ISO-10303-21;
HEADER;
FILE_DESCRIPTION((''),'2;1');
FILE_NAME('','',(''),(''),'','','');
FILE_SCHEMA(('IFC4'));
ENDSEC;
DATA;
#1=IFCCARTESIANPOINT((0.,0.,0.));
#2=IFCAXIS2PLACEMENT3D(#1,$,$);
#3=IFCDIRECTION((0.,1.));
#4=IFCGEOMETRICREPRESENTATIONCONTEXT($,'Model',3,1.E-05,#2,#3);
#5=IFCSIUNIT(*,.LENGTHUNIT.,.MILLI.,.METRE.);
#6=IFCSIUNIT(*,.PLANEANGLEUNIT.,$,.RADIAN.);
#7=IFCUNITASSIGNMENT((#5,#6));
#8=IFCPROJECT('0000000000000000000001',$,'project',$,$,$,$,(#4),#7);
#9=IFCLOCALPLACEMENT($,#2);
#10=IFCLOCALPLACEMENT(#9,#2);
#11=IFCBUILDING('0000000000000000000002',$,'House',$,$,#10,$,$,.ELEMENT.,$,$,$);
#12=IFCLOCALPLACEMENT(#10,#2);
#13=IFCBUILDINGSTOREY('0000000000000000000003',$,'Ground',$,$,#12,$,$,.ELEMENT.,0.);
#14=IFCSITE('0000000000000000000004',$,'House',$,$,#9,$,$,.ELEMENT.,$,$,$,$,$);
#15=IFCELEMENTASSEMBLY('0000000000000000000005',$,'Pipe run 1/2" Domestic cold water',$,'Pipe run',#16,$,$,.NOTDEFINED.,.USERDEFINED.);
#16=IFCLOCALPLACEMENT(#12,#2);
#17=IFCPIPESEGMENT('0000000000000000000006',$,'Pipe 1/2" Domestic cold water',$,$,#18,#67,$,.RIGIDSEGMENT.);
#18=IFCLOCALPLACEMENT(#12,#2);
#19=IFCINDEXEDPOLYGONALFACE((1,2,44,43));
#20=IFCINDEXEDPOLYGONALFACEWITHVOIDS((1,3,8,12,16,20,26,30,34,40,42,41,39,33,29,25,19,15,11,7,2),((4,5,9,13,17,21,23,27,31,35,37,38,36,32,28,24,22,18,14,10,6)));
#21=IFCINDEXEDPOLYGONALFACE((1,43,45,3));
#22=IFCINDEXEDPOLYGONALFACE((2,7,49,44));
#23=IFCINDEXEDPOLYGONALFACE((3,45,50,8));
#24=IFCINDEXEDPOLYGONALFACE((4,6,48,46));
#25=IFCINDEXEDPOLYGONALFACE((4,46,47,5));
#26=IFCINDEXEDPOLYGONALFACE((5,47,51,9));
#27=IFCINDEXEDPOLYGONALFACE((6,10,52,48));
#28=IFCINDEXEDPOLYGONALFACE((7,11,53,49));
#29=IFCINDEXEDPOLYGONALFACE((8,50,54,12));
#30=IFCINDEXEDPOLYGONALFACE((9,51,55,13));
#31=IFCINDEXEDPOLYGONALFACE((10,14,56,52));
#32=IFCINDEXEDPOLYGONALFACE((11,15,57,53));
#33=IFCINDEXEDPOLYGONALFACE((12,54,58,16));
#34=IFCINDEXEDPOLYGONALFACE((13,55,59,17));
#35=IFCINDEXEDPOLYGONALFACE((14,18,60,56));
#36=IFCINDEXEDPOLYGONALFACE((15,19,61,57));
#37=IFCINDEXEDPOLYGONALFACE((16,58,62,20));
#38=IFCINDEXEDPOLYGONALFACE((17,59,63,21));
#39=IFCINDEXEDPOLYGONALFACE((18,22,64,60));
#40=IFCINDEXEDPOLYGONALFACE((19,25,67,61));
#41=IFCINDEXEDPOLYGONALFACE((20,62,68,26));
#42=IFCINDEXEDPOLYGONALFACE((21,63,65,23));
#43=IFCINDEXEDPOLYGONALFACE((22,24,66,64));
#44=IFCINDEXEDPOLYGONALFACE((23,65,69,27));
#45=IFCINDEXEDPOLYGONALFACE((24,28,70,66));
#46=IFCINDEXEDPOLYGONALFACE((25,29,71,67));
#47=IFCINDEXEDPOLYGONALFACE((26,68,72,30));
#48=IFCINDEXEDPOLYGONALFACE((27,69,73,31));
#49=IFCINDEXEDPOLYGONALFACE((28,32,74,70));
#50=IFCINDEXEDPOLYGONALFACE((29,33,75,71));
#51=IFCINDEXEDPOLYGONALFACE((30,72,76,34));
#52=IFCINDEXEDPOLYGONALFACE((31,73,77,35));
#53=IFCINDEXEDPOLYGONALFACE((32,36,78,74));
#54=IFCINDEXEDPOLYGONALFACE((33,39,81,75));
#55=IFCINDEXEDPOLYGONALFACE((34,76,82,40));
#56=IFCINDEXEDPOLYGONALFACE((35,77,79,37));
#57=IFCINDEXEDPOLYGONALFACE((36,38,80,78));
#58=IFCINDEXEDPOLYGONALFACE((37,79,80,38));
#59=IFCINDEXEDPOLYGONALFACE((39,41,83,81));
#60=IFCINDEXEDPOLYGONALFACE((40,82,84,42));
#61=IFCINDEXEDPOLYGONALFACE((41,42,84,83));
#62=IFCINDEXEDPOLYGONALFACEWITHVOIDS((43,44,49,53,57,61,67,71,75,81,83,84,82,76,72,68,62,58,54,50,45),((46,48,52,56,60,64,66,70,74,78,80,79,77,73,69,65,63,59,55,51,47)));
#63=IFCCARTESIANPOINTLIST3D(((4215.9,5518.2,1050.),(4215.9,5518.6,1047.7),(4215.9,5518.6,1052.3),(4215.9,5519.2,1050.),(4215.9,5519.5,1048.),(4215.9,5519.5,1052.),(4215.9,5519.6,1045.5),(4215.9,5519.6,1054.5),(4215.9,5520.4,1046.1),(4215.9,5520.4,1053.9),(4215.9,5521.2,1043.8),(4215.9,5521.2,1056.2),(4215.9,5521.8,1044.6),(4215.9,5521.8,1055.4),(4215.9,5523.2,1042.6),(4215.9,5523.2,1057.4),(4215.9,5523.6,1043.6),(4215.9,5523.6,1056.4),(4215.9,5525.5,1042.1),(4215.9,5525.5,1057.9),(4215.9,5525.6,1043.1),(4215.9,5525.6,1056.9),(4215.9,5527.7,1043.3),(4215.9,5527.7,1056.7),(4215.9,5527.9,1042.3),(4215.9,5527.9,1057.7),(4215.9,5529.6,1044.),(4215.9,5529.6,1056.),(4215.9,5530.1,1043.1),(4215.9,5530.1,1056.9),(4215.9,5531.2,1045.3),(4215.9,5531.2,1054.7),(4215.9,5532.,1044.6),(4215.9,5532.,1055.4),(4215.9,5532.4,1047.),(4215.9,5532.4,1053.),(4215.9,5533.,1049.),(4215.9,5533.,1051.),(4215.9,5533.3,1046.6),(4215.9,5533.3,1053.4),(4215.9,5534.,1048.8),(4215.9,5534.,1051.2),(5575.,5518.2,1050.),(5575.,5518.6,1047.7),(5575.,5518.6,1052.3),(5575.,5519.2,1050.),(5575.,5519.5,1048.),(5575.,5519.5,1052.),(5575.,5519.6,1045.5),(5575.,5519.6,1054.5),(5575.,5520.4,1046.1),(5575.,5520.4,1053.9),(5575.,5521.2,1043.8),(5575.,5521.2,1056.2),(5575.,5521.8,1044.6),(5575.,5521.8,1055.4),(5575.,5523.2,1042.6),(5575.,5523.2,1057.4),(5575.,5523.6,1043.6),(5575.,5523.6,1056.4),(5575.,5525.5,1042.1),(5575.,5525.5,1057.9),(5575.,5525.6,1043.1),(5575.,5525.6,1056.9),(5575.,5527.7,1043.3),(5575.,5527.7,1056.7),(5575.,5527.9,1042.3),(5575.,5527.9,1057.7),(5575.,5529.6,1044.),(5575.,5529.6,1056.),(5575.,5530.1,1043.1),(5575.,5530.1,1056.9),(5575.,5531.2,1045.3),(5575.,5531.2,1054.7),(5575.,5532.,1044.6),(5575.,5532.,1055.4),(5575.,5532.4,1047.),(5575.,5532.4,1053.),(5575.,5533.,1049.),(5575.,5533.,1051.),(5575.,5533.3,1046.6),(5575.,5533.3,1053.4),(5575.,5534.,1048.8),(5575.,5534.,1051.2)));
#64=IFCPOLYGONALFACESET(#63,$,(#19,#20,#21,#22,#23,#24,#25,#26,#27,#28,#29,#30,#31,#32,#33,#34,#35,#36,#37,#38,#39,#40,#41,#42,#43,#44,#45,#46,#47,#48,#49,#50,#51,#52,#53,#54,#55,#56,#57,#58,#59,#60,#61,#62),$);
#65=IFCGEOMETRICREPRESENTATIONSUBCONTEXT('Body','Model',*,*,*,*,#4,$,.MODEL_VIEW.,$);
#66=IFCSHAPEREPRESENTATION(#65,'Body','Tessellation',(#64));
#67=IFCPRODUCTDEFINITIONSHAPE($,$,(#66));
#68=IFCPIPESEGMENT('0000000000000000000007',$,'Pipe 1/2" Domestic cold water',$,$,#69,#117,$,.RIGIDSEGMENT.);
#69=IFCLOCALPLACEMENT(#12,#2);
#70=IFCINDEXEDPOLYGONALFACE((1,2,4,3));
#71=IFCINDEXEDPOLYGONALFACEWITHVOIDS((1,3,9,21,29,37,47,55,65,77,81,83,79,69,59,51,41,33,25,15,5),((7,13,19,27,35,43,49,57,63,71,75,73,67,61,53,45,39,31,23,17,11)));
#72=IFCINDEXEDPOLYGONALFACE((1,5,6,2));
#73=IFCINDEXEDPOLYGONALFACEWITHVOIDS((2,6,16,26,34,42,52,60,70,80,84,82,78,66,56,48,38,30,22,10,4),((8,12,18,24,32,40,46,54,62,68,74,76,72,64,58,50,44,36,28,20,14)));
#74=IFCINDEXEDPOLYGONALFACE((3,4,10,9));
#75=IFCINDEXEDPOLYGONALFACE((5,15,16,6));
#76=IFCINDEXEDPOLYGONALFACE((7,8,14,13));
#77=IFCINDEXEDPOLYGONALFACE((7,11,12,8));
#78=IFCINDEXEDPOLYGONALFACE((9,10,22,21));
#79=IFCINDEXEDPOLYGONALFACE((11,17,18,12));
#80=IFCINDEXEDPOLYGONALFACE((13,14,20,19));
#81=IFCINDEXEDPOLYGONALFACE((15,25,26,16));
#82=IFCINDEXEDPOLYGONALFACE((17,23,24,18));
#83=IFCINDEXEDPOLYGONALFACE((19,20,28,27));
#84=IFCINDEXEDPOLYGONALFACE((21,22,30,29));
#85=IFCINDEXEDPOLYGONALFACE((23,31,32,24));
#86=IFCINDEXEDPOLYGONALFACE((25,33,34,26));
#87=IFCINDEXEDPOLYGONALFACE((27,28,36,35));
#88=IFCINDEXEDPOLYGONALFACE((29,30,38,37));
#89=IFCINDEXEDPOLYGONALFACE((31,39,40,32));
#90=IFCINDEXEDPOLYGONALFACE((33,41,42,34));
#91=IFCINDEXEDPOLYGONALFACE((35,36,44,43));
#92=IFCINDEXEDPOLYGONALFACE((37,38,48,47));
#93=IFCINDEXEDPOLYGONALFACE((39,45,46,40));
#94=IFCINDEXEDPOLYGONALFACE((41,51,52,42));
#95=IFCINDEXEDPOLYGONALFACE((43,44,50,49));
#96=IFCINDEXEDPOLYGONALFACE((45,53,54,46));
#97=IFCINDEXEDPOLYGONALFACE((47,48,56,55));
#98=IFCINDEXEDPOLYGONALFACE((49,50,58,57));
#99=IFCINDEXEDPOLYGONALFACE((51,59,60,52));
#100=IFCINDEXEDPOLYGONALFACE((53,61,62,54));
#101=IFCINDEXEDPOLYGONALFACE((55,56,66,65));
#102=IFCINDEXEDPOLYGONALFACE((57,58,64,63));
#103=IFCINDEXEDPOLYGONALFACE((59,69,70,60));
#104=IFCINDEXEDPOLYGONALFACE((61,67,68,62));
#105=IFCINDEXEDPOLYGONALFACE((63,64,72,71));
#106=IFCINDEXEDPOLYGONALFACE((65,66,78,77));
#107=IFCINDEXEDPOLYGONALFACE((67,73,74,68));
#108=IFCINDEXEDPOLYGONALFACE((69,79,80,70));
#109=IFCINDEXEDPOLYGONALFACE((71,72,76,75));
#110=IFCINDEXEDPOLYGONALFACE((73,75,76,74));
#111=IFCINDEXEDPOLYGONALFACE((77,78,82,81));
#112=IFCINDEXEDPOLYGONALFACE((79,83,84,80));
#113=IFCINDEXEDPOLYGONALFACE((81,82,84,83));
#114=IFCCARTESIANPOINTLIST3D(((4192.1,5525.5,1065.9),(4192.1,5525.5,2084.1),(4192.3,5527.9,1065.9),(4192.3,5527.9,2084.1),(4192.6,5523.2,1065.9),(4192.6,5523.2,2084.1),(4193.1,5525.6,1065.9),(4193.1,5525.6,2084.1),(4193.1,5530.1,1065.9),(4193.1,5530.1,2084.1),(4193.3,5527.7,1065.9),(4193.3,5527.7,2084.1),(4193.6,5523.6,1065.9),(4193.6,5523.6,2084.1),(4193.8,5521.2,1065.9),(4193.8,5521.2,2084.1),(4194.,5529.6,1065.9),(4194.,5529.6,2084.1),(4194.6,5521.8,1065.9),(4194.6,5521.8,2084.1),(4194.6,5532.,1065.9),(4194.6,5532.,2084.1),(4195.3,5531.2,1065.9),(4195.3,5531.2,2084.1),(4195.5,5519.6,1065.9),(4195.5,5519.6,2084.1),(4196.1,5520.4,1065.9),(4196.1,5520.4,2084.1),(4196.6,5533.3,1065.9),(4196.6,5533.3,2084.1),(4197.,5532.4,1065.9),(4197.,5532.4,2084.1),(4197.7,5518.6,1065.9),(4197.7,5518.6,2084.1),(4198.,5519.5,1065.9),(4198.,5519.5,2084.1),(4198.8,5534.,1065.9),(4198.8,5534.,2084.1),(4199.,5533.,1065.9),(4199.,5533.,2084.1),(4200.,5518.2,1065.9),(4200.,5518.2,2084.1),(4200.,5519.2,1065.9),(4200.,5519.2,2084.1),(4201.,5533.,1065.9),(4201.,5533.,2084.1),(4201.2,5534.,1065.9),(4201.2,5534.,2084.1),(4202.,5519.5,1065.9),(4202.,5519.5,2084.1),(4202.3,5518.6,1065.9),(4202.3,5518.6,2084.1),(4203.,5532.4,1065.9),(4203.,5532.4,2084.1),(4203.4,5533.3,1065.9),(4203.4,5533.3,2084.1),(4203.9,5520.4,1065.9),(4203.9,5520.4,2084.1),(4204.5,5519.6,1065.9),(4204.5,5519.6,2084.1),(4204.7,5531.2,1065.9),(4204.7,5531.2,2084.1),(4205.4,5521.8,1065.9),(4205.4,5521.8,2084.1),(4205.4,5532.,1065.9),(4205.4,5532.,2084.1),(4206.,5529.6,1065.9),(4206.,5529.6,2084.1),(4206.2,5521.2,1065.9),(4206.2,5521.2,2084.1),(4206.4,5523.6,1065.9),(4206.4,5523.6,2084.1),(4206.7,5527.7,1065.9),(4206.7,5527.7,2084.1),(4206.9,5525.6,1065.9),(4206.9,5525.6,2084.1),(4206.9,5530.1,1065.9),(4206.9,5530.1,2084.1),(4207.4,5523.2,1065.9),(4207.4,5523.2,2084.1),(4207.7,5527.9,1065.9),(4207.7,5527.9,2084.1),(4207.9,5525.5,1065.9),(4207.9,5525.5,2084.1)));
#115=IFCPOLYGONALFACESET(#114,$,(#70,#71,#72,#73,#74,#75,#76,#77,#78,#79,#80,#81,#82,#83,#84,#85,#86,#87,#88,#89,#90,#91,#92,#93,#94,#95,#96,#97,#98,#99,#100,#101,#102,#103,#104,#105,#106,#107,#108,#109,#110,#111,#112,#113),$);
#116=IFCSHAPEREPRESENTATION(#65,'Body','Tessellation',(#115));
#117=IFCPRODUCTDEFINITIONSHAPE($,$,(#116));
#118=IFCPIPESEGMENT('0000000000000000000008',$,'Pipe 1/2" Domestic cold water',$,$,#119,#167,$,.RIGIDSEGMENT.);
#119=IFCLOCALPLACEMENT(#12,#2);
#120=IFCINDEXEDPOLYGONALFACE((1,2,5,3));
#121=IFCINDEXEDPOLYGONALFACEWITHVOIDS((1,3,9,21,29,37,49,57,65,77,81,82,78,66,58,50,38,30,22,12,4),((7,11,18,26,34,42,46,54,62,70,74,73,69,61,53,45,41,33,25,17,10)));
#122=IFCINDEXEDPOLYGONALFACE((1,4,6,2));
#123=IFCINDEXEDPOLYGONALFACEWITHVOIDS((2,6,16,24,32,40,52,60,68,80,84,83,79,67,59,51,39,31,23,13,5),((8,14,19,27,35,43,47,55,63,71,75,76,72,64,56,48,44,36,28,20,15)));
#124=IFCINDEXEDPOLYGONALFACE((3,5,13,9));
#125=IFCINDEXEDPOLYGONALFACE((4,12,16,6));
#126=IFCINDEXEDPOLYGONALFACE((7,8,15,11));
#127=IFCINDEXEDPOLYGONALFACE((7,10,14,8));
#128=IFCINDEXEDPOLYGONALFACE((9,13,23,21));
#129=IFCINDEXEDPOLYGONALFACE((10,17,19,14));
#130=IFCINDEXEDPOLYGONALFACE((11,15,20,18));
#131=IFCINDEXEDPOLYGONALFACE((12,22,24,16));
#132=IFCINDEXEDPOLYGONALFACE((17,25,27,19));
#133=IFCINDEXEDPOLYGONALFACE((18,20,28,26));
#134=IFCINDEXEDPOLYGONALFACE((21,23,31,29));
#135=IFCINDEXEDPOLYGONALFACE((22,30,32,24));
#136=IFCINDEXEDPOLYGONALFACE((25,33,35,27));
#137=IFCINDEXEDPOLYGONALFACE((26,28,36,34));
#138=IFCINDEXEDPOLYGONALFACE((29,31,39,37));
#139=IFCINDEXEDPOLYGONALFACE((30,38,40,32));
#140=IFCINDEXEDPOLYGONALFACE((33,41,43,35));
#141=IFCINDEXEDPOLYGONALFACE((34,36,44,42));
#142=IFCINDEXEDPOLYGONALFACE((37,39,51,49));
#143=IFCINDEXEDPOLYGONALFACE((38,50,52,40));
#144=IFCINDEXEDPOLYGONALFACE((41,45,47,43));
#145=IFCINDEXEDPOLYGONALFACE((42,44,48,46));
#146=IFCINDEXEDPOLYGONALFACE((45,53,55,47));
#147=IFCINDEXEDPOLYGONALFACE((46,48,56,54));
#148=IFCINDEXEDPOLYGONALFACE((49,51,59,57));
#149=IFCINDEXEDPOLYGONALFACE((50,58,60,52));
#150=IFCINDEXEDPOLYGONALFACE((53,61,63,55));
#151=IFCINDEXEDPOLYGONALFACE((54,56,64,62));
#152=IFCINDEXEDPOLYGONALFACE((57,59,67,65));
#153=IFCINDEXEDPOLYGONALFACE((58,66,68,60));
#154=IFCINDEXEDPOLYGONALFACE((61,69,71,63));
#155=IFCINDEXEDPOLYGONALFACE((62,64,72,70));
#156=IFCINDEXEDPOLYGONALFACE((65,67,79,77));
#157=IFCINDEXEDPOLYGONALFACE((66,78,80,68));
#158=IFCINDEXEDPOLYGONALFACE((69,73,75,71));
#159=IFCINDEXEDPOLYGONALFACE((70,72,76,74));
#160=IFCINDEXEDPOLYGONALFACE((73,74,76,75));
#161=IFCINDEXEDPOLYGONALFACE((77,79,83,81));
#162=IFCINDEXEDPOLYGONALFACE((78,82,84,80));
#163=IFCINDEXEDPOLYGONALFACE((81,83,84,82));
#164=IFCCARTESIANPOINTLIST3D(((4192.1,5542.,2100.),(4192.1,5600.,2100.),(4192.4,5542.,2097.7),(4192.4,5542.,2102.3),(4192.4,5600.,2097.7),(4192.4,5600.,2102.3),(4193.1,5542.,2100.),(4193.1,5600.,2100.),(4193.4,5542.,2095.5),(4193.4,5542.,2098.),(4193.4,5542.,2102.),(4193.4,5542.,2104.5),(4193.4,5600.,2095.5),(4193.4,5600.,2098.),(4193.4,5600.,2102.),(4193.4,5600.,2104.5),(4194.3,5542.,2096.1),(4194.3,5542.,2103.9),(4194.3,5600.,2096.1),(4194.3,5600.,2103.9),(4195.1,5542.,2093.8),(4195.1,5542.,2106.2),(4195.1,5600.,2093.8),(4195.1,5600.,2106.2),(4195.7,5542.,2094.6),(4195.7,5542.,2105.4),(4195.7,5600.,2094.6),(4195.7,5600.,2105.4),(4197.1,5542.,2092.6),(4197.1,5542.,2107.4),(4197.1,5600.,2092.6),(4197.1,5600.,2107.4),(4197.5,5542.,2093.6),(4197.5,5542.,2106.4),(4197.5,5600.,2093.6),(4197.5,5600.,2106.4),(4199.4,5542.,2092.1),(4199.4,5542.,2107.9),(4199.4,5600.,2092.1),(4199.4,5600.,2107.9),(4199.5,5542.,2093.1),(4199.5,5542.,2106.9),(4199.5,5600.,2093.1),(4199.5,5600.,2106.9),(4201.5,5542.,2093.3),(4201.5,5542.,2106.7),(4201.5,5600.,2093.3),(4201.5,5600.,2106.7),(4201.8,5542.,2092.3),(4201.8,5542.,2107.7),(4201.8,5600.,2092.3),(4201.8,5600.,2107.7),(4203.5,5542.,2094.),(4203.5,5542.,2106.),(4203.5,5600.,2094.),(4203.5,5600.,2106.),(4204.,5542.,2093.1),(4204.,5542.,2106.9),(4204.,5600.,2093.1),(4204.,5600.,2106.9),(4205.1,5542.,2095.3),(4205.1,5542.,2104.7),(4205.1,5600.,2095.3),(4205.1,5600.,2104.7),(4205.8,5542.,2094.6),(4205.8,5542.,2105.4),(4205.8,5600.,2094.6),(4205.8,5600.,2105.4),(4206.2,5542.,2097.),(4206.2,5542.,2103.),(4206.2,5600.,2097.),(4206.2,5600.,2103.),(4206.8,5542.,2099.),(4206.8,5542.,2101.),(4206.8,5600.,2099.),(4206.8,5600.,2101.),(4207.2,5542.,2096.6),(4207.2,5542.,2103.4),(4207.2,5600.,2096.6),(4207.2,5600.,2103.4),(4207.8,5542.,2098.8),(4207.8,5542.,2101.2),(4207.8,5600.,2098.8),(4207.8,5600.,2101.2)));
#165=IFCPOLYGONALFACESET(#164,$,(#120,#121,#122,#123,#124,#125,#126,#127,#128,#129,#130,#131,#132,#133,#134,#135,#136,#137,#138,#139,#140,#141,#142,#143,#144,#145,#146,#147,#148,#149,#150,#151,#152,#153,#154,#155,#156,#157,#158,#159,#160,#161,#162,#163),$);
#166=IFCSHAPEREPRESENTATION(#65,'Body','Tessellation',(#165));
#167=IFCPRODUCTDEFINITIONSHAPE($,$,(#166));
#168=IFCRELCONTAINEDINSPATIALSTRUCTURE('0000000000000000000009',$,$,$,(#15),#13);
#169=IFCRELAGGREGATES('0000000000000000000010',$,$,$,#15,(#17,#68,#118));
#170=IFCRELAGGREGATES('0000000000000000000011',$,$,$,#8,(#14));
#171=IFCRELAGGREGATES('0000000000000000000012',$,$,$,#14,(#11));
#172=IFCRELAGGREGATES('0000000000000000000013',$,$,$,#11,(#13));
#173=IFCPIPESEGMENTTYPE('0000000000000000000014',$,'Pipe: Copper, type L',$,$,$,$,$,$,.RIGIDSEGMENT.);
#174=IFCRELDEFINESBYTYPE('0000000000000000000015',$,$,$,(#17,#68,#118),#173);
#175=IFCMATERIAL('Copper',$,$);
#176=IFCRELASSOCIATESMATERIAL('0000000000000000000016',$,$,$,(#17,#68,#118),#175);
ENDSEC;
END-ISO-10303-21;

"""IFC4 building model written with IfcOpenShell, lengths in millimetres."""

from ifc_helpers import new_model, si_unit, direction, frame, origin, origin_with_axes, origin_2d, place, context, subcontext, project, spatial, hollow_circle, extrude, material, type_object, element, aggregate, save


model = new_model("IFC4")

# Units and contexts
model_context = context("Model", 3, precision=1e-05, world=origin(), true_north=direction((0.0, 1.0)))
body_context = subcontext(model_context, "Body", "Model", "MODEL_VIEW")
ifc_project = project(units=[si_unit("LENGTHUNIT", "METRE", prefix="MILLI"), si_unit("PLANEANGLEUNIT", "RADIAN")], contexts=[model_context])

# Site, building, storey
site_placement = place(None, origin())
site = spatial("IfcSite", under=ifc_project, at=site_placement, Name="House", CompositionType="ELEMENT")
building_placement = place(site_placement, origin())
building = spatial("IfcBuilding", under=site, at=building_placement, Name="House", CompositionType="ELEMENT")
storey_placement = place(building_placement, origin())
storey = spatial("IfcBuildingStorey", under=building, at=storey_placement, Name="Ground", CompositionType="ELEMENT", Elevation=0.0)

# Element assembly, pipe segments
ifc_material = material(Name="Copper")
pipe_segment_type = type_object("IfcPipeSegmentType", Name="Pipe: Copper, type L", PredefinedType="RIGIDSEGMENT")
assembly_1_placement = place(storey_placement, origin_with_axes())
assembly_1 = element("IfcElementAssembly", 1, at=assembly_1_placement, inside=storey, Name="Pipe run 1/2\" Domestic cold water", ObjectType="Pipe run", AssemblyPlace="NOTDEFINED", PredefinedType="USERDEFINED")
pipe_segment_1_placement = place(storey_placement, origin_with_axes())
pipe_segment_1 = element("IfcPipeSegment", 2, at=pipe_segment_1_placement, type_object=pipe_segment_type, material=ifc_material, Name="Pipe 1/2\" Domestic cold water", PredefinedType="RIGIDSEGMENT", context=body_context, shape_type="SweptSolid", body=[
    extrude(hollow_circle(Radius=7.9, WallThickness=1.0, at=origin_2d()), frame((5575.0, 5526.1, 1050.0), z_axis=(-1.0, 0.0, 0.0), x_axis=(0.0, -1.0, 0.0)), (0.0, 0.0, 1.0), 1359.1),
])
pipe_segment_2_placement = place(storey_placement, origin_with_axes())
pipe_segment_2 = element("IfcPipeSegment", 3, at=pipe_segment_2_placement, type_object=pipe_segment_type, material=ifc_material, Name="Pipe 1/2\" Domestic cold water", PredefinedType="RIGIDSEGMENT", context=body_context, shape_type="SweptSolid", body=[
    extrude(hollow_circle(Radius=7.9, WallThickness=1.0, at=origin_2d()), frame((4200.0, 5526.1, 1065.9), z_axis=(0.0, 0.0, 1.0), x_axis=(0.0, -1.0, 0.0)), (0.0, 0.0, 1.0), 1018.2),
])
pipe_segment_3_placement = place(storey_placement, origin_with_axes())
pipe_segment_3 = element("IfcPipeSegment", 4, at=pipe_segment_3_placement, type_object=pipe_segment_type, material=ifc_material, Name="Pipe 1/2\" Domestic cold water", PredefinedType="RIGIDSEGMENT", context=body_context, shape_type="SweptSolid", body=[
    extrude(hollow_circle(Radius=7.9, WallThickness=1.0, at=origin_2d()), frame((4200.0, 5542.0, 2100.0), z_axis=(0.0, 1.0, 0.0), x_axis=(-1.0, 0.0, 0.0)), (0.0, 0.0, 1.0), 58.0),
])

aggregate(assembly_1, [pipe_segment_1, pipe_segment_2, pipe_segment_3])

save(model, "model.ifc")
